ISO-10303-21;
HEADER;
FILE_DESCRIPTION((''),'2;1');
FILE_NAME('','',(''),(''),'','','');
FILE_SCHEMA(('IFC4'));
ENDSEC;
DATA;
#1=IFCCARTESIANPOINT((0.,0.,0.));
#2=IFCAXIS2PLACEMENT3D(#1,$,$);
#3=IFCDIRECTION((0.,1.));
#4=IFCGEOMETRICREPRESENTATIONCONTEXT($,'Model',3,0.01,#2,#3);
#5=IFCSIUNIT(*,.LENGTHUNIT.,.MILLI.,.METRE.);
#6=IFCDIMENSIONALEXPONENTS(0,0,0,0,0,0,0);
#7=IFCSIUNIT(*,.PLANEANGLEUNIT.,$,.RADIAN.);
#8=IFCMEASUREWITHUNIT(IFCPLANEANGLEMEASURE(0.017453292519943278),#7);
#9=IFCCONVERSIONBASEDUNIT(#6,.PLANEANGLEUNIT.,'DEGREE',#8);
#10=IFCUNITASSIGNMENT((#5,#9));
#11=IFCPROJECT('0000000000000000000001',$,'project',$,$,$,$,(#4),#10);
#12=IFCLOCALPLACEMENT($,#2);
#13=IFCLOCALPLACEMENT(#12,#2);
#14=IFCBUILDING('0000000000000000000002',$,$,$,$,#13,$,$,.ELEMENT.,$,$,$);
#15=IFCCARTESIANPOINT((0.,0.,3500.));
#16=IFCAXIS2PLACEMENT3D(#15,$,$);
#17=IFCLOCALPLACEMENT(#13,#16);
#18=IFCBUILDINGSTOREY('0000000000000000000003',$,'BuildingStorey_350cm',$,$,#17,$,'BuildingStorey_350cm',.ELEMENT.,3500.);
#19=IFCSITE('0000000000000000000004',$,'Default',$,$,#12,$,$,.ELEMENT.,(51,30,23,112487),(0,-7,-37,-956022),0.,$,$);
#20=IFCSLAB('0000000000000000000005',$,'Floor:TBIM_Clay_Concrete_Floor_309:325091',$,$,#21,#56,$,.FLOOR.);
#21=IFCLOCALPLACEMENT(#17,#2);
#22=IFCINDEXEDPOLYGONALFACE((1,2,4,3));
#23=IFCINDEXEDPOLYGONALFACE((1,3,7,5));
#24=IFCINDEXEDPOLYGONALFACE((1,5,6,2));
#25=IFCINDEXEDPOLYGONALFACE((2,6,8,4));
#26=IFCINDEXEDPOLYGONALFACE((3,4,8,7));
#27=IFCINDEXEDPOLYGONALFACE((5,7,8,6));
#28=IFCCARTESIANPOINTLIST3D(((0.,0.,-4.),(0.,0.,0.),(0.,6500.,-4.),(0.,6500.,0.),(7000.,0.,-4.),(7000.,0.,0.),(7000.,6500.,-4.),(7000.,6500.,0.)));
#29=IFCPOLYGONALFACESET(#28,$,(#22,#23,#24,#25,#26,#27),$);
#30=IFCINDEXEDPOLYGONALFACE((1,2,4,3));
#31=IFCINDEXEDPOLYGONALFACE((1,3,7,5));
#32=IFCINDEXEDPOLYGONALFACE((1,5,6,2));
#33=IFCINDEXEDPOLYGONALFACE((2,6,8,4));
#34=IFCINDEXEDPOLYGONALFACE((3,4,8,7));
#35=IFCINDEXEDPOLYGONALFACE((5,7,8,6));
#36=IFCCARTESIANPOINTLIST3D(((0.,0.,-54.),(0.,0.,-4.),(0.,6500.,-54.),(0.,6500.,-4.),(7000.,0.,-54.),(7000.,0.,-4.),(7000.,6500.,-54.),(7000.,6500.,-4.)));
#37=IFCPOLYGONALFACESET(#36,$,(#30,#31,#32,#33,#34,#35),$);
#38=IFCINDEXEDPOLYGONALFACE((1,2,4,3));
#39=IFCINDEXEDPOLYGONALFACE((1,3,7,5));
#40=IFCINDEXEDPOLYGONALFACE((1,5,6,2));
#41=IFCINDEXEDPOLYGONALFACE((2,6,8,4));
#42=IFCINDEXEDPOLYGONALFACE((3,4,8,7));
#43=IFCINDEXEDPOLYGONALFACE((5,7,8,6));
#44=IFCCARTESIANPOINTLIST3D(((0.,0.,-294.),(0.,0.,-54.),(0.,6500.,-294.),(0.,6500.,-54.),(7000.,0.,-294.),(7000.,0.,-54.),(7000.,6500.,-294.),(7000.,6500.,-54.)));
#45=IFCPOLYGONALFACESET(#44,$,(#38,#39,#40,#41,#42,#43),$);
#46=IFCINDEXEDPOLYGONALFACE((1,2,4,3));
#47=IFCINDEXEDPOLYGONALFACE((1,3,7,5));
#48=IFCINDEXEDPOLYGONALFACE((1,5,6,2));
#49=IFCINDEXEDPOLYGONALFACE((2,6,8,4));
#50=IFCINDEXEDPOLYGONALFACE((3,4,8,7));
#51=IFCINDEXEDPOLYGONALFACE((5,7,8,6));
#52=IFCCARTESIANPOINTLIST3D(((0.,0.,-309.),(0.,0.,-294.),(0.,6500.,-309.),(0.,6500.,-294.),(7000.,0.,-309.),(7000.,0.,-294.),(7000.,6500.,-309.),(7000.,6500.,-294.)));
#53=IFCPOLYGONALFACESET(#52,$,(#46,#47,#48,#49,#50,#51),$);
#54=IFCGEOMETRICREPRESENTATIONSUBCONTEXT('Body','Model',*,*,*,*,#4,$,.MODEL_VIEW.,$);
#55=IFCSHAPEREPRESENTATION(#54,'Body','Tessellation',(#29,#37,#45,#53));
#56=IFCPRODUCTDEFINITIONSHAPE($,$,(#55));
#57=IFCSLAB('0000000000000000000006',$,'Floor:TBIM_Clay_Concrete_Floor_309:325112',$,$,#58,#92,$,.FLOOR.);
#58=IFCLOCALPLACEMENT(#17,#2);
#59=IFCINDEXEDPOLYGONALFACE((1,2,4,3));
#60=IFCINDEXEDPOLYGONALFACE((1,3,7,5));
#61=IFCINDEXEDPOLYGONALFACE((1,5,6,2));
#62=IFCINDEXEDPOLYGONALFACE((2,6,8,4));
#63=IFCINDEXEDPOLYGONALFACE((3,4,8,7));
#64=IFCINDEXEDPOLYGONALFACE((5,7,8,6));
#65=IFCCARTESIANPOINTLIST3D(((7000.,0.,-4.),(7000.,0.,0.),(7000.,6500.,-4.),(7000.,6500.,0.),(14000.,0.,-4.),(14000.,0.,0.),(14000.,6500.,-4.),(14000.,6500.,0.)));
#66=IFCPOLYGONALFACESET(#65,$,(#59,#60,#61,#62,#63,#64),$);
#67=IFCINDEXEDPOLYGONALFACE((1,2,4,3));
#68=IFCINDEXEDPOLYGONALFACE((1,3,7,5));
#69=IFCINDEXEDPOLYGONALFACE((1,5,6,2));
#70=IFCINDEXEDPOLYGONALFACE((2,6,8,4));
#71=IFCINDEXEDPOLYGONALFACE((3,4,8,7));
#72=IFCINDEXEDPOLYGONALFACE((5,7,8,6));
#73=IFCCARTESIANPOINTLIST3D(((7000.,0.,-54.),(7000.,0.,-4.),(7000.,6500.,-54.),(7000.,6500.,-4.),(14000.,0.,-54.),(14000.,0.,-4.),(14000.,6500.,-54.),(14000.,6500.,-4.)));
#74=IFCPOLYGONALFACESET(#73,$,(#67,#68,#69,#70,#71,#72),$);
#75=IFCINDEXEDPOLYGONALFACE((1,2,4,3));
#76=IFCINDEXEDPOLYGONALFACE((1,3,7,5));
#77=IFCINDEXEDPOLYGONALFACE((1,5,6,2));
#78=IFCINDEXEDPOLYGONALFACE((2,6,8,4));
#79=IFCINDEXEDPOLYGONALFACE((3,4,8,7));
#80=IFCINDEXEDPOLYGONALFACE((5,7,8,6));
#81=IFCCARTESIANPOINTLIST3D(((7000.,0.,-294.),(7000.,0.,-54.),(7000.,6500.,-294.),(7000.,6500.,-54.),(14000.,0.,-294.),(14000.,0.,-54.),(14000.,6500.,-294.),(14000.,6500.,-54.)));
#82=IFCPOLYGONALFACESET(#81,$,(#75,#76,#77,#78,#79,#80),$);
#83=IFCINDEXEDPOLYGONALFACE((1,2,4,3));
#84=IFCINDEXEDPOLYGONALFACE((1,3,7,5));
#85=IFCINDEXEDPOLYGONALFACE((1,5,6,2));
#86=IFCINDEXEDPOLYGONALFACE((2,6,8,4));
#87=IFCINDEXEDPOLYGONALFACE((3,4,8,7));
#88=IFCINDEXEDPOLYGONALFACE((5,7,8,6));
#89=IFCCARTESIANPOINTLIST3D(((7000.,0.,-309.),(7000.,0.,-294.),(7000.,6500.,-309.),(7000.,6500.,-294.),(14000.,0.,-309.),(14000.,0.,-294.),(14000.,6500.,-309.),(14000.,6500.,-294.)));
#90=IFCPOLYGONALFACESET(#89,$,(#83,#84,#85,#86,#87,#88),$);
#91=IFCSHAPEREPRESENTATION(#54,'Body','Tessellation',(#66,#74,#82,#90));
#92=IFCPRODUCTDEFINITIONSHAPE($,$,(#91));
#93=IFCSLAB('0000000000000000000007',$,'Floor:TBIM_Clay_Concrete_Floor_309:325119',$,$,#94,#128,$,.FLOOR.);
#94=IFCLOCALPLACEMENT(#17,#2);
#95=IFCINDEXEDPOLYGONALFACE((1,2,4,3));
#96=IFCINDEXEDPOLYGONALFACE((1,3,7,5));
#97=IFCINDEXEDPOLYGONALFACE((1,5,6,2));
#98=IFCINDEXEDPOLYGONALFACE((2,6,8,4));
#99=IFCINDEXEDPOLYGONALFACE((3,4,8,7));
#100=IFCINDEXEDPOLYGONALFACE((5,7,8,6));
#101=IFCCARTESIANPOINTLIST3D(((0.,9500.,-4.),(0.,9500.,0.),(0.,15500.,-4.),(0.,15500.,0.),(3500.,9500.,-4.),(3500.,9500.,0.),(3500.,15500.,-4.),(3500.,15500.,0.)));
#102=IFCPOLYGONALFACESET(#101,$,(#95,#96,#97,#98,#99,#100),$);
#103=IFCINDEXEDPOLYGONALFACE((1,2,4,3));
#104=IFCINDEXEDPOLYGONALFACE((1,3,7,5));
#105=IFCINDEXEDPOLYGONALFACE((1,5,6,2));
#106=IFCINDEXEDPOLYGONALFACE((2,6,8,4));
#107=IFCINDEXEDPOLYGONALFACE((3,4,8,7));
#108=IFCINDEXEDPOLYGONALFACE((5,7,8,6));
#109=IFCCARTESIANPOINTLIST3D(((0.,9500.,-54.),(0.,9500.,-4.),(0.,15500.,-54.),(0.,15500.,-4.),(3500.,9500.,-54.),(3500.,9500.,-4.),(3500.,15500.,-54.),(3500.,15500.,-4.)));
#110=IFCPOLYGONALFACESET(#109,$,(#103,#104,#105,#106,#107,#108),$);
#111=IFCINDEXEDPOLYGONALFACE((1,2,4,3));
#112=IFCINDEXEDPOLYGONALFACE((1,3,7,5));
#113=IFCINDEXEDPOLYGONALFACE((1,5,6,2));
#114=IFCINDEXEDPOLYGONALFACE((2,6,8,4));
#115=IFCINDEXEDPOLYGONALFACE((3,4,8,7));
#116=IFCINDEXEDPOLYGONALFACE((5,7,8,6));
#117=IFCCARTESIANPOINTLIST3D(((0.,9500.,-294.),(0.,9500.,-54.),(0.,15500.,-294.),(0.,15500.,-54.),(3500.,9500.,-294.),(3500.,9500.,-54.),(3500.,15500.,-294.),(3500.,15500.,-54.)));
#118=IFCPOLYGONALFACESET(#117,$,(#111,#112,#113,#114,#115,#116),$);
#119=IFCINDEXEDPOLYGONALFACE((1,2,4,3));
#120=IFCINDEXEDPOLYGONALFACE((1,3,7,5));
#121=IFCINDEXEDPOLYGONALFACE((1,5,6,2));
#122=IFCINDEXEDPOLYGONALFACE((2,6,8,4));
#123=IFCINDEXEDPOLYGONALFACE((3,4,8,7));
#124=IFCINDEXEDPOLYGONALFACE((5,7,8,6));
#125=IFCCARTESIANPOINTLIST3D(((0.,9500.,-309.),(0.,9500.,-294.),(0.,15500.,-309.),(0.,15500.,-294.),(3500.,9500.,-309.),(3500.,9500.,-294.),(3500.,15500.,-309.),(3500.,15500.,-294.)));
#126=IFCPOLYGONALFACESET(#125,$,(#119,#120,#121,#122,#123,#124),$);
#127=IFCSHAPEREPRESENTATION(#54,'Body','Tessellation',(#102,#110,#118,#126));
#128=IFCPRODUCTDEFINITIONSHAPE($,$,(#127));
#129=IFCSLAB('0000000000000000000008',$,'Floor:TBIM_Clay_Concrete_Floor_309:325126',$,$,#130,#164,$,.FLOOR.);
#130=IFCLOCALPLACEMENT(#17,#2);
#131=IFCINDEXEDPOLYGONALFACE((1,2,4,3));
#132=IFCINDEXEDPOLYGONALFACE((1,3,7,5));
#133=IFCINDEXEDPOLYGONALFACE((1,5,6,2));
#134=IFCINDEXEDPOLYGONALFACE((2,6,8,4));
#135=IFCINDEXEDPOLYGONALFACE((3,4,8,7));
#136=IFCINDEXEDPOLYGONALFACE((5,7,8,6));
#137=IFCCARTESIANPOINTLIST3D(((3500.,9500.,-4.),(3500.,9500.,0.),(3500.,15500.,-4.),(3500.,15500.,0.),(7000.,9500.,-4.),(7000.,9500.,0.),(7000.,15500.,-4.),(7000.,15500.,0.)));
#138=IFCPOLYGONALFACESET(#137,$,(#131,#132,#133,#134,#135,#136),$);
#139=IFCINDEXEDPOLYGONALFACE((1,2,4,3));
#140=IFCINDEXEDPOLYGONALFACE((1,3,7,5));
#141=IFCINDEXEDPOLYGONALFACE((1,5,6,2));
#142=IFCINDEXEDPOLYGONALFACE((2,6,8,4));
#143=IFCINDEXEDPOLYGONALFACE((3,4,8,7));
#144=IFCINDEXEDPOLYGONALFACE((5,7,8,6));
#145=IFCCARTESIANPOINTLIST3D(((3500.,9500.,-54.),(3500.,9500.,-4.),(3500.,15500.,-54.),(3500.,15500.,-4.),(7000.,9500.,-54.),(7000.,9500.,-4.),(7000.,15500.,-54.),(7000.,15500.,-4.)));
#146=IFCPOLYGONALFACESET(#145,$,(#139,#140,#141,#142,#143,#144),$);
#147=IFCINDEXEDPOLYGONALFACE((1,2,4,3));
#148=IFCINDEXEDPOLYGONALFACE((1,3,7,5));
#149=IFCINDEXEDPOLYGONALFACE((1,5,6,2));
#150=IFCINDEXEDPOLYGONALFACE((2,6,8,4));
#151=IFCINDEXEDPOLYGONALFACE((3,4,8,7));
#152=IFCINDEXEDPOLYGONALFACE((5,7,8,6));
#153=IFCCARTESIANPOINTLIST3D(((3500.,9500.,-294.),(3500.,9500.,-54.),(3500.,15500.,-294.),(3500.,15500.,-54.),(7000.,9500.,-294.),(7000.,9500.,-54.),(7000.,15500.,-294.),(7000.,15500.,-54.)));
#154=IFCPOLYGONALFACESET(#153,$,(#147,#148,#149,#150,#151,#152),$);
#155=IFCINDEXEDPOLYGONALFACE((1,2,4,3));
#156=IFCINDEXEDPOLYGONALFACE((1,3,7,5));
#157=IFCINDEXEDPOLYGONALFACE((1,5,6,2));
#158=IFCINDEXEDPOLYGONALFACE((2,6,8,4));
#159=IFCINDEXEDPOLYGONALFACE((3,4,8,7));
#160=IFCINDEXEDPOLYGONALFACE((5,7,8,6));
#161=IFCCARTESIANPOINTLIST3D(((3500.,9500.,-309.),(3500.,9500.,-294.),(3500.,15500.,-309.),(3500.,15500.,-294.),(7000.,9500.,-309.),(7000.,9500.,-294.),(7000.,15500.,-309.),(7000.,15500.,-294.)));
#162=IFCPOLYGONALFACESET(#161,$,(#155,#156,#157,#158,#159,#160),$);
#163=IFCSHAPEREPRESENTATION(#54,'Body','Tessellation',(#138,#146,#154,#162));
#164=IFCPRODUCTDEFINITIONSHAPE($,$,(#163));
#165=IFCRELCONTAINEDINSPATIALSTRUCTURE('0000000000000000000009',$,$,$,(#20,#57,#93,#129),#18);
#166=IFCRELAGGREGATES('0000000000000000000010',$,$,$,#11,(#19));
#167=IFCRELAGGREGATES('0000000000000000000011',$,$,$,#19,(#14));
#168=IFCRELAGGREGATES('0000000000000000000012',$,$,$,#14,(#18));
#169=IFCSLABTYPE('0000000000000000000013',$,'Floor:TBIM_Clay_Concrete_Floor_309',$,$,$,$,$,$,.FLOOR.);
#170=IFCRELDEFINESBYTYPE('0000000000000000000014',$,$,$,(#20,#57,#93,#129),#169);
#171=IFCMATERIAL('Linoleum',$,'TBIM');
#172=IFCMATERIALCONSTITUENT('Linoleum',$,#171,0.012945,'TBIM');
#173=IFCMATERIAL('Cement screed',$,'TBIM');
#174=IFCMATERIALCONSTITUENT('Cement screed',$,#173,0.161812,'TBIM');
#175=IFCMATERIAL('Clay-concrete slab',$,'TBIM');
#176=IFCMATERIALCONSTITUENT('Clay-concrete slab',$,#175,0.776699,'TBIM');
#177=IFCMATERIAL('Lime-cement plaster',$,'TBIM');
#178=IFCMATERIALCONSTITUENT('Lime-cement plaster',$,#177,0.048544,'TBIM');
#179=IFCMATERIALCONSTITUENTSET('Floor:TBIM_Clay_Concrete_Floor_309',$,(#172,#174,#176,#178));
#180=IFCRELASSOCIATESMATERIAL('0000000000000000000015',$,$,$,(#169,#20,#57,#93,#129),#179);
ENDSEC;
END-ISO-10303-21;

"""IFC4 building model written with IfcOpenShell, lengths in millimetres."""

from ifc_helpers import new_model, entity, si_unit, converted_unit, direction, frame, origin, place, context, subcontext, project, spatial, indexed_curve, outline, extrude, material, constituent, constituent_set, type_object, element, save


model = new_model("IFC4")

# Units and contexts
model_context = context("Model", 3, precision=0.01, world=origin(), true_north=direction((0.0, 1.0)))
body_context = subcontext(model_context, "Body", "Model", "MODEL_VIEW")
ifc_project = project(units=[si_unit("LENGTHUNIT", "METRE", prefix="MILLI"), converted_unit("PLANEANGLEUNIT", "DEGREE", entity("IfcPlaneAngleMeasure", 0.017453292519943278), si_unit("PLANEANGLEUNIT", "RADIAN"), dimensions=[0, 0, 0, 0, 0, 0, 0])], contexts=[model_context])

# Site, building, storey
site_placement = place(None, origin())
site = spatial("IfcSite", under=ifc_project, at=site_placement, Name="Default", CompositionType="ELEMENT", RefLatitude=(51, 30, 23, 112487), RefLongitude=(0, -7, -37, -956022), RefElevation=0.0)
building_placement = place(site_placement, origin())
building = spatial("IfcBuilding", under=site, at=building_placement, CompositionType="ELEMENT")
storey_placement = place(building_placement, frame((0.0, 0.0, 3500.0)))
storey = spatial("IfcBuildingStorey", under=building, at=storey_placement, Name="BuildingStorey_350cm", LongName="BuildingStorey_350cm", CompositionType="ELEMENT", Elevation=3500.0)

# Slabs
ifc_material_1 = material(Name="Linoleum", Category="TBIM")
ifc_constituent_1 = constituent(ifc_material_1, Name="Linoleum", Category="TBIM", fraction=0.012945)
ifc_material_2 = material(Name="Cement screed", Category="TBIM")
ifc_constituent_2 = constituent(ifc_material_2, Name="Cement screed", Category="TBIM", fraction=0.161812)
ifc_material_3 = material(Name="Clay-concrete slab", Category="TBIM")
ifc_constituent_3 = constituent(ifc_material_3, Name="Clay-concrete slab", Category="TBIM", fraction=0.776699)
ifc_material_4 = material(Name="Lime-cement plaster", Category="TBIM")
ifc_constituent_4 = constituent(ifc_material_4, Name="Lime-cement plaster", Category="TBIM", fraction=0.048544)
ifc_constituent_set_1 = constituent_set(constituents=[ifc_constituent_1, ifc_constituent_2, ifc_constituent_3, ifc_constituent_4], Name="Floor:TBIM_Clay_Concrete_Floor_309")
slab_type = type_object("IfcSlabType", Name="Floor:TBIM_Clay_Concrete_Floor_309", PredefinedType="FLOOR", material=ifc_constituent_set_1)
slab_1_placement = place(storey_placement, origin())
element("IfcSlab", 1, at=slab_1_placement, inside=storey, type_object=slab_type, material=ifc_constituent_set_1, Name="Floor:TBIM_Clay_Concrete_Floor_309:325091", PredefinedType="FLOOR", context=body_context, shape_type="SweptSolid", body=[
    extrude(outline(indexed_curve([(-3500.0, -3250.0), (3500.0, -3250.0), (3500.0, 3250.0), (-3500.0, 3250.0), (-3500.0, -3250.0)], self_intersect=False)), frame((3500.0, 3250.0, -4.0), z_axis=(0.0, 0.0, 1.0), x_axis=(-1.0, 0.0, 0.0)), (0.0, 0.0, 1.0), 4.0),
    extrude(outline(indexed_curve([(-3500.0, -3250.0), (3500.0, -3250.0), (3500.0, 3250.0), (-3500.0, 3250.0), (-3500.0, -3250.0)], self_intersect=False)), frame((3500.0, 3250.0, -54.0), z_axis=(0.0, 0.0, 1.0), x_axis=(-1.0, 0.0, 0.0)), (0.0, 0.0, 1.0), 50.0),
    extrude(outline(indexed_curve([(-3500.0, -3250.0), (3500.0, -3250.0), (3500.0, 3250.0), (-3500.0, 3250.0), (-3500.0, -3250.0)], self_intersect=False)), frame((3500.0, 3250.0, -294.0), z_axis=(0.0, 0.0, 1.0), x_axis=(-1.0, 0.0, 0.0)), (0.0, 0.0, 1.0), 240.0),
    extrude(outline(indexed_curve([(-3500.0, -3250.0), (3500.0, -3250.0), (3500.0, 3250.0), (-3500.0, 3250.0), (-3500.0, -3250.0)], self_intersect=False)), frame((3500.0, 3250.0, -309.0), z_axis=(0.0, 0.0, 1.0), x_axis=(-1.0, 0.0, 0.0)), (0.0, 0.0, 1.0), 15.0),
])
slab_2_placement = place(storey_placement, origin())
element("IfcSlab", 2, at=slab_2_placement, inside=storey, type_object=slab_type, material=ifc_constituent_set_1, Name="Floor:TBIM_Clay_Concrete_Floor_309:325112", PredefinedType="FLOOR", context=body_context, shape_type="SweptSolid", body=[
    extrude(outline(indexed_curve([(-3500.0, -3250.0), (3500.0, -3250.0), (3500.0, 3250.0), (-3500.0, 3250.0), (-3500.0, -3250.0)], self_intersect=False)), frame((10500.0, 3250.0, -4.0), z_axis=(0.0, 0.0, 1.0), x_axis=(-1.0, 0.0, 0.0)), (0.0, 0.0, 1.0), 4.0),
    extrude(outline(indexed_curve([(-3500.0, -3250.0), (3500.0, -3250.0), (3500.0, 3250.0), (-3500.0, 3250.0), (-3500.0, -3250.0)], self_intersect=False)), frame((10500.0, 3250.0, -54.0), z_axis=(0.0, 0.0, 1.0), x_axis=(-1.0, 0.0, 0.0)), (0.0, 0.0, 1.0), 50.0),
    extrude(outline(indexed_curve([(-3500.0, -3250.0), (3500.0, -3250.0), (3500.0, 3250.0), (-3500.0, 3250.0), (-3500.0, -3250.0)], self_intersect=False)), frame((10500.0, 3250.0, -294.0), z_axis=(0.0, 0.0, 1.0), x_axis=(-1.0, 0.0, 0.0)), (0.0, 0.0, 1.0), 240.0),
    extrude(outline(indexed_curve([(-3500.0, -3250.0), (3500.0, -3250.0), (3500.0, 3250.0), (-3500.0, 3250.0), (-3500.0, -3250.0)], self_intersect=False)), frame((10500.0, 3250.0, -309.0), z_axis=(0.0, 0.0, 1.0), x_axis=(-1.0, 0.0, 0.0)), (0.0, 0.0, 1.0), 15.0),
])
slab_3_placement = place(storey_placement, origin())
element("IfcSlab", 3, at=slab_3_placement, inside=storey, type_object=slab_type, material=ifc_constituent_set_1, Name="Floor:TBIM_Clay_Concrete_Floor_309:325119", PredefinedType="FLOOR", context=body_context, shape_type="SweptSolid", body=[
    extrude(outline(indexed_curve([(-1750.0, -3000.0), (1750.0, -3000.0), (1750.0, 3000.0), (-1750.0, 3000.0), (-1750.0, -3000.0)], self_intersect=False)), frame((1750.0, 12500.0, -4.0), z_axis=(0.0, 0.0, 1.0), x_axis=(-1.0, 0.0, 0.0)), (0.0, 0.0, 1.0), 4.0),
    extrude(outline(indexed_curve([(-1750.0, -3000.0), (1750.0, -3000.0), (1750.0, 3000.0), (-1750.0, 3000.0), (-1750.0, -3000.0)], self_intersect=False)), frame((1750.0, 12500.0, -54.0), z_axis=(0.0, 0.0, 1.0), x_axis=(-1.0, 0.0, 0.0)), (0.0, 0.0, 1.0), 50.0),
    extrude(outline(indexed_curve([(-1750.0, -3000.0), (1750.0, -3000.0), (1750.0, 3000.0), (-1750.0, 3000.0), (-1750.0, -3000.0)], self_intersect=False)), frame((1750.0, 12500.0, -294.0), z_axis=(0.0, 0.0, 1.0), x_axis=(-1.0, 0.0, 0.0)), (0.0, 0.0, 1.0), 240.0),
    extrude(outline(indexed_curve([(-1750.0, -3000.0), (1750.0, -3000.0), (1750.0, 3000.0), (-1750.0, 3000.0), (-1750.0, -3000.0)], self_intersect=False)), frame((1750.0, 12500.0, -309.0), z_axis=(0.0, 0.0, 1.0), x_axis=(-1.0, 0.0, 0.0)), (0.0, 0.0, 1.0), 15.0),
])
slab_4_placement = place(storey_placement, origin())
element("IfcSlab", 4, at=slab_4_placement, inside=storey, type_object=slab_type, material=ifc_constituent_set_1, Name="Floor:TBIM_Clay_Concrete_Floor_309:325126", PredefinedType="FLOOR", context=body_context, shape_type="SweptSolid", body=[
    extrude(outline(indexed_curve([(-1750.0, -3000.0), (1750.0, -3000.0), (1750.0, 3000.0), (-1750.0, 3000.0), (-1750.0, -3000.0)], self_intersect=False)), frame((5250.0, 12500.0, -4.0), z_axis=(0.0, 0.0, 1.0), x_axis=(-1.0, 0.0, 0.0)), (0.0, 0.0, 1.0), 4.0),
    extrude(outline(indexed_curve([(-1750.0, -3000.0), (1750.0, -3000.0), (1750.0, 3000.0), (-1750.0, 3000.0), (-1750.0, -3000.0)], self_intersect=False)), frame((5250.0, 12500.0, -54.0), z_axis=(0.0, 0.0, 1.0), x_axis=(-1.0, 0.0, 0.0)), (0.0, 0.0, 1.0), 50.0),
    extrude(outline(indexed_curve([(-1750.0, -3000.0), (1750.0, -3000.0), (1750.0, 3000.0), (-1750.0, 3000.0), (-1750.0, -3000.0)], self_intersect=False)), frame((5250.0, 12500.0, -294.0), z_axis=(0.0, 0.0, 1.0), x_axis=(-1.0, 0.0, 0.0)), (0.0, 0.0, 1.0), 240.0),
    extrude(outline(indexed_curve([(-1750.0, -3000.0), (1750.0, -3000.0), (1750.0, 3000.0), (-1750.0, 3000.0), (-1750.0, -3000.0)], self_intersect=False)), frame((5250.0, 12500.0, -309.0), z_axis=(0.0, 0.0, 1.0), x_axis=(-1.0, 0.0, 0.0)), (0.0, 0.0, 1.0), 15.0),
])

save(model, "model.ifc")
